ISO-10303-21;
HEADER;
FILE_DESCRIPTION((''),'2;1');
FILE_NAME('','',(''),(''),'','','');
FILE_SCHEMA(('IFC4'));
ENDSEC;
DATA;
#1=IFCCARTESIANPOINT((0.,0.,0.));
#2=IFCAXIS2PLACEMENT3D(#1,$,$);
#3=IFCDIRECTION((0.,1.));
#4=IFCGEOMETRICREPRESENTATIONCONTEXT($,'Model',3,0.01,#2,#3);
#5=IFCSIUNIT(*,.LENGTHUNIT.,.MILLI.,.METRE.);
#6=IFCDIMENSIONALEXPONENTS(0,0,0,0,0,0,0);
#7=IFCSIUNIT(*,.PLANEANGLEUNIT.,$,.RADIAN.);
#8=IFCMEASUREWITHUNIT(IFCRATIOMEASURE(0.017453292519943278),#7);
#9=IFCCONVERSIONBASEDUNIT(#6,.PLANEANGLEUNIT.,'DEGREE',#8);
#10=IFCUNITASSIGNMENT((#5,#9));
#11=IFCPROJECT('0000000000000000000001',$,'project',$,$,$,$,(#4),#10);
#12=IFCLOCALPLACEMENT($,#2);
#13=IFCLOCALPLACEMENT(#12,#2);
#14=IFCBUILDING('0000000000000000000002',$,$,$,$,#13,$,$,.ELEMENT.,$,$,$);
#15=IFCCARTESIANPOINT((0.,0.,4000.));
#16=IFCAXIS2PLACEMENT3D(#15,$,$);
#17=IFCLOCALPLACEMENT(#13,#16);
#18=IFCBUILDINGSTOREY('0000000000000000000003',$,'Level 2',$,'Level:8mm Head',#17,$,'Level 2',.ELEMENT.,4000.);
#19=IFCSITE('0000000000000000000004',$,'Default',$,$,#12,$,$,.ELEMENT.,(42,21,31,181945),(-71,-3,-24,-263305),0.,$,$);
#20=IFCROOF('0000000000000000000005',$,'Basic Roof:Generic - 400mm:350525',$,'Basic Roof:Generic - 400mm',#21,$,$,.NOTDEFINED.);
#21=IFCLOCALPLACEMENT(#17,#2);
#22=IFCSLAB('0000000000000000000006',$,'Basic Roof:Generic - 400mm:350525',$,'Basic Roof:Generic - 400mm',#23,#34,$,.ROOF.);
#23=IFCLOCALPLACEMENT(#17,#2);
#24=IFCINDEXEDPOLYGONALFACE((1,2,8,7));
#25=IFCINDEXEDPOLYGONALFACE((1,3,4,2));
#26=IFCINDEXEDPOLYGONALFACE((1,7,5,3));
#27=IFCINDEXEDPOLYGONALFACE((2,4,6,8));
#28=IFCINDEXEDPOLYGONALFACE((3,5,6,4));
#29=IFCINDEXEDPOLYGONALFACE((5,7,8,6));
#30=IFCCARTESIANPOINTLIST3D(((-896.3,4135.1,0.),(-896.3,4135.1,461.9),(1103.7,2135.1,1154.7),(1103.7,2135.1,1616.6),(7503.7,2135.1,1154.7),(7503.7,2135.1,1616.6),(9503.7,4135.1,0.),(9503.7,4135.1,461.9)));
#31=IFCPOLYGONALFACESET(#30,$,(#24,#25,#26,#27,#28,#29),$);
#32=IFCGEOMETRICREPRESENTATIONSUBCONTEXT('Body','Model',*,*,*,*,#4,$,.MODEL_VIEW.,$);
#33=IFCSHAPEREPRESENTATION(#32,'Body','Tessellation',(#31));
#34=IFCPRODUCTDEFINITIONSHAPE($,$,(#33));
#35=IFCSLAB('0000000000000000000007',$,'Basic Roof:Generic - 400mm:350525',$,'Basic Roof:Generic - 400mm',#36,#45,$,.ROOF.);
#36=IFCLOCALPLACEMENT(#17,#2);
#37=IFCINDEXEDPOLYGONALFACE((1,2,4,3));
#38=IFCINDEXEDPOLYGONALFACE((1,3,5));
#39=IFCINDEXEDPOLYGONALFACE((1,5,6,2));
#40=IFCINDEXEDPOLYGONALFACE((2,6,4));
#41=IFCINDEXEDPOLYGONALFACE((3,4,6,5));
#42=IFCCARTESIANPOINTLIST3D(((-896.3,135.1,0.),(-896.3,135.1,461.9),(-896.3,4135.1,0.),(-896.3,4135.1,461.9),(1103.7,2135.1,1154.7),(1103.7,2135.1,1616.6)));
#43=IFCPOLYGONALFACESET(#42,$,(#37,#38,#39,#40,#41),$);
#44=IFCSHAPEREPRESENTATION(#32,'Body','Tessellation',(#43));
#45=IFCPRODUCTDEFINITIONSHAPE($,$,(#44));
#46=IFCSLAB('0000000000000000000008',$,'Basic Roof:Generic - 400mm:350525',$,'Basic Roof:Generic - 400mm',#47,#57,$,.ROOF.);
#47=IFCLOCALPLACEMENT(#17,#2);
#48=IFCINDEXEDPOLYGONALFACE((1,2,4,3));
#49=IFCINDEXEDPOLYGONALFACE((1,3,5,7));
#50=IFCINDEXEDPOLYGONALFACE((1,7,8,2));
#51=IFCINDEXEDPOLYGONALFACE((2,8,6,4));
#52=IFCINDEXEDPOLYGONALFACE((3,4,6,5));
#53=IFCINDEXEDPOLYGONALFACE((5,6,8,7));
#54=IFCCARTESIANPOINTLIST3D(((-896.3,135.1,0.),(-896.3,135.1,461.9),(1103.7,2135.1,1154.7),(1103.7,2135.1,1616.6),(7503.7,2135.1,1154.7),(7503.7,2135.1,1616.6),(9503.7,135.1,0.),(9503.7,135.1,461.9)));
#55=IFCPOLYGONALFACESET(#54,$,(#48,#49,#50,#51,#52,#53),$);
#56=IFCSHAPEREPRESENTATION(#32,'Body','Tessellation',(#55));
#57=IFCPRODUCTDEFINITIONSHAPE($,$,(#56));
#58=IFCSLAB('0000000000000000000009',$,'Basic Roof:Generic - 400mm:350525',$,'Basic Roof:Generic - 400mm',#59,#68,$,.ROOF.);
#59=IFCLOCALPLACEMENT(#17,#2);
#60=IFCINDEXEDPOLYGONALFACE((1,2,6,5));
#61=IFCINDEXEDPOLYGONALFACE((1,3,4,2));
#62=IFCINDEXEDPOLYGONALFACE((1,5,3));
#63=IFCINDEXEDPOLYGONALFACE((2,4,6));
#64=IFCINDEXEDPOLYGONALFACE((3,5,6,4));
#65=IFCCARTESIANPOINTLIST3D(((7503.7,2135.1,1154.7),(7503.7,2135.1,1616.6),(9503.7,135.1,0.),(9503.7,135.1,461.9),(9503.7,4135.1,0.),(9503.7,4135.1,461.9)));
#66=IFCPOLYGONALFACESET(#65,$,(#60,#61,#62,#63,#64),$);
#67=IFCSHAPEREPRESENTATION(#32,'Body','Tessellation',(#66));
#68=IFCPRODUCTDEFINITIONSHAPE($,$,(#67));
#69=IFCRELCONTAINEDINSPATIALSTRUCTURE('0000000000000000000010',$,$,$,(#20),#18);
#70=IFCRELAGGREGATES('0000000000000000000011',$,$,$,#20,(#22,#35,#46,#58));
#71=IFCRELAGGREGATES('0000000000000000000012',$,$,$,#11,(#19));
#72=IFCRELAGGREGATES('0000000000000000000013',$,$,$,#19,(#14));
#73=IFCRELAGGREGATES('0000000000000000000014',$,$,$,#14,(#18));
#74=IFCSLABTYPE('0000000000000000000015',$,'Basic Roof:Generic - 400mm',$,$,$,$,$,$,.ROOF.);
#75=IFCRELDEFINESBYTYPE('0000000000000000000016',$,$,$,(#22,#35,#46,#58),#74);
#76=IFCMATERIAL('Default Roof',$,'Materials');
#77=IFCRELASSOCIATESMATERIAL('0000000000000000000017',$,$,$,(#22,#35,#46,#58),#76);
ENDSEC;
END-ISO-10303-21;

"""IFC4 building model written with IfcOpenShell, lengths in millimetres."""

from ifc_helpers import new_model, entity, si_unit, converted_unit, direction, frame, origin, place, context, subcontext, project, spatial, indexed_curve, outline, extrude, material, type_object, element, aggregate, save


model = new_model("IFC4")

# Units and contexts
model_context = context("Model", 3, precision=0.01, world=origin(), true_north=direction((0.0, 1.0)))
body_context = subcontext(model_context, "Body", "Model", "MODEL_VIEW")
ifc_project = project(units=[si_unit("LENGTHUNIT", "METRE", prefix="MILLI"), converted_unit("PLANEANGLEUNIT", "DEGREE", entity("IfcRatioMeasure", 0.017453292519943278), si_unit("PLANEANGLEUNIT", "RADIAN"), dimensions=[0, 0, 0, 0, 0, 0, 0])], contexts=[model_context])

# Site, building, storey
site_placement = place(None, origin())
site = spatial("IfcSite", under=ifc_project, at=site_placement, Name="Default", CompositionType="ELEMENT", RefLatitude=(42, 21, 31, 181945), RefLongitude=(-71, -3, -24, -263305), RefElevation=0.0)
building_placement = place(site_placement, origin())
building = spatial("IfcBuilding", under=site, at=building_placement, CompositionType="ELEMENT")
storey_placement = place(building_placement, frame((0.0, 0.0, 4000.0)))
storey = spatial("IfcBuildingStorey", under=building, at=storey_placement, Name="Level 2", ObjectType="Level:8mm Head", LongName="Level 2", CompositionType="ELEMENT", Elevation=4000.0)

# Roof, slabs
roof_placement = place(storey_placement, frame((-896.3, 135.1, 0.0)))
roof = element("IfcRoof", 1, at=roof_placement, inside=storey, Name="Basic Roof:Generic - 400mm:350525", ObjectType="Basic Roof:Generic - 400mm", PredefinedType="NOTDEFINED")
ifc_material = material(Name="Default Roof", Category="Materials")
slab_type = type_object("IfcSlabType", Name="Basic Roof:Generic - 400mm", PredefinedType="ROOF")
slab_1_placement = place(roof_placement, origin())
slab_1 = element("IfcSlab", 2, at=slab_1_placement, type_object=slab_type, material=ifc_material, Name="Basic Roof:Generic - 400mm:350525", ObjectType="Basic Roof:Generic - 400mm", PredefinedType="ROOF", context=body_context, shape_type="SweptSolid", body=[
    extrude(outline(indexed_curve([(5200.0, 1154.7), (-5200.0, 1154.7), (-3200.0, -1154.7), (3200.0, -1154.7), (5200.0, 1154.7)], self_intersect=False)), frame((5200.0, 3000.0, 577.4), z_axis=(0.0, 0.5, 0.866025), x_axis=(1.0, 0.0, 0.0)), (0.0, -0.5, 0.866025), 461.9),
])
slab_2_placement = place(roof_placement, origin())
slab_2 = element("IfcSlab", 3, at=slab_2_placement, type_object=slab_type, material=ifc_material, Name="Basic Roof:Generic - 400mm:350525", ObjectType="Basic Roof:Generic - 400mm", PredefinedType="ROOF", context=body_context, shape_type="SweptSolid", body=[
    extrude(outline(indexed_curve([(-1154.7, 2000.0), (-1154.7, -2000.0), (1154.7, 0.0), (-1154.7, 2000.0)], self_intersect=False)), frame((1000.0, 2000.0, 577.4), z_axis=(-0.5, 0.0, 0.866025), x_axis=(0.866025, 0.0, 0.5)), (0.5, 0.0, 0.866025), 461.9),
])
slab_3_placement = place(roof_placement, origin())
slab_3 = element("IfcSlab", 4, at=slab_3_placement, type_object=slab_type, material=ifc_material, Name="Basic Roof:Generic - 400mm:350525", ObjectType="Basic Roof:Generic - 400mm", PredefinedType="ROOF", context=body_context, shape_type="SweptSolid", body=[
    extrude(outline(indexed_curve([(-5200.0, -1154.7), (5200.0, -1154.7), (3200.0, 1154.7), (-3200.0, 1154.7), (-5200.0, -1154.7)], self_intersect=False)), frame((5200.0, 1000.0, 577.4), z_axis=(0.0, -0.5, 0.866025), x_axis=(1.0, 0.0, 0.0)), (0.0, 0.5, 0.866025), 461.9),
])
slab_4_placement = place(roof_placement, origin())
slab_4 = element("IfcSlab", 5, at=slab_4_placement, type_object=slab_type, material=ifc_material, Name="Basic Roof:Generic - 400mm:350525", ObjectType="Basic Roof:Generic - 400mm", PredefinedType="ROOF", context=body_context, shape_type="SweptSolid", body=[
    extrude(outline(indexed_curve([(-1154.7, 0.0), (1154.7, -2000.0), (1154.7, 2000.0), (-1154.7, 0.0)], self_intersect=False)), frame((9400.0, 2000.0, 577.4), z_axis=(0.5, 0.0, 0.866025), x_axis=(0.866025, 0.0, -0.5)), (-0.5, 0.0, 0.866025), 461.9),
])
aggregate(roof, [slab_1, slab_2, slab_3, slab_4])

save(model, "model.ifc")
